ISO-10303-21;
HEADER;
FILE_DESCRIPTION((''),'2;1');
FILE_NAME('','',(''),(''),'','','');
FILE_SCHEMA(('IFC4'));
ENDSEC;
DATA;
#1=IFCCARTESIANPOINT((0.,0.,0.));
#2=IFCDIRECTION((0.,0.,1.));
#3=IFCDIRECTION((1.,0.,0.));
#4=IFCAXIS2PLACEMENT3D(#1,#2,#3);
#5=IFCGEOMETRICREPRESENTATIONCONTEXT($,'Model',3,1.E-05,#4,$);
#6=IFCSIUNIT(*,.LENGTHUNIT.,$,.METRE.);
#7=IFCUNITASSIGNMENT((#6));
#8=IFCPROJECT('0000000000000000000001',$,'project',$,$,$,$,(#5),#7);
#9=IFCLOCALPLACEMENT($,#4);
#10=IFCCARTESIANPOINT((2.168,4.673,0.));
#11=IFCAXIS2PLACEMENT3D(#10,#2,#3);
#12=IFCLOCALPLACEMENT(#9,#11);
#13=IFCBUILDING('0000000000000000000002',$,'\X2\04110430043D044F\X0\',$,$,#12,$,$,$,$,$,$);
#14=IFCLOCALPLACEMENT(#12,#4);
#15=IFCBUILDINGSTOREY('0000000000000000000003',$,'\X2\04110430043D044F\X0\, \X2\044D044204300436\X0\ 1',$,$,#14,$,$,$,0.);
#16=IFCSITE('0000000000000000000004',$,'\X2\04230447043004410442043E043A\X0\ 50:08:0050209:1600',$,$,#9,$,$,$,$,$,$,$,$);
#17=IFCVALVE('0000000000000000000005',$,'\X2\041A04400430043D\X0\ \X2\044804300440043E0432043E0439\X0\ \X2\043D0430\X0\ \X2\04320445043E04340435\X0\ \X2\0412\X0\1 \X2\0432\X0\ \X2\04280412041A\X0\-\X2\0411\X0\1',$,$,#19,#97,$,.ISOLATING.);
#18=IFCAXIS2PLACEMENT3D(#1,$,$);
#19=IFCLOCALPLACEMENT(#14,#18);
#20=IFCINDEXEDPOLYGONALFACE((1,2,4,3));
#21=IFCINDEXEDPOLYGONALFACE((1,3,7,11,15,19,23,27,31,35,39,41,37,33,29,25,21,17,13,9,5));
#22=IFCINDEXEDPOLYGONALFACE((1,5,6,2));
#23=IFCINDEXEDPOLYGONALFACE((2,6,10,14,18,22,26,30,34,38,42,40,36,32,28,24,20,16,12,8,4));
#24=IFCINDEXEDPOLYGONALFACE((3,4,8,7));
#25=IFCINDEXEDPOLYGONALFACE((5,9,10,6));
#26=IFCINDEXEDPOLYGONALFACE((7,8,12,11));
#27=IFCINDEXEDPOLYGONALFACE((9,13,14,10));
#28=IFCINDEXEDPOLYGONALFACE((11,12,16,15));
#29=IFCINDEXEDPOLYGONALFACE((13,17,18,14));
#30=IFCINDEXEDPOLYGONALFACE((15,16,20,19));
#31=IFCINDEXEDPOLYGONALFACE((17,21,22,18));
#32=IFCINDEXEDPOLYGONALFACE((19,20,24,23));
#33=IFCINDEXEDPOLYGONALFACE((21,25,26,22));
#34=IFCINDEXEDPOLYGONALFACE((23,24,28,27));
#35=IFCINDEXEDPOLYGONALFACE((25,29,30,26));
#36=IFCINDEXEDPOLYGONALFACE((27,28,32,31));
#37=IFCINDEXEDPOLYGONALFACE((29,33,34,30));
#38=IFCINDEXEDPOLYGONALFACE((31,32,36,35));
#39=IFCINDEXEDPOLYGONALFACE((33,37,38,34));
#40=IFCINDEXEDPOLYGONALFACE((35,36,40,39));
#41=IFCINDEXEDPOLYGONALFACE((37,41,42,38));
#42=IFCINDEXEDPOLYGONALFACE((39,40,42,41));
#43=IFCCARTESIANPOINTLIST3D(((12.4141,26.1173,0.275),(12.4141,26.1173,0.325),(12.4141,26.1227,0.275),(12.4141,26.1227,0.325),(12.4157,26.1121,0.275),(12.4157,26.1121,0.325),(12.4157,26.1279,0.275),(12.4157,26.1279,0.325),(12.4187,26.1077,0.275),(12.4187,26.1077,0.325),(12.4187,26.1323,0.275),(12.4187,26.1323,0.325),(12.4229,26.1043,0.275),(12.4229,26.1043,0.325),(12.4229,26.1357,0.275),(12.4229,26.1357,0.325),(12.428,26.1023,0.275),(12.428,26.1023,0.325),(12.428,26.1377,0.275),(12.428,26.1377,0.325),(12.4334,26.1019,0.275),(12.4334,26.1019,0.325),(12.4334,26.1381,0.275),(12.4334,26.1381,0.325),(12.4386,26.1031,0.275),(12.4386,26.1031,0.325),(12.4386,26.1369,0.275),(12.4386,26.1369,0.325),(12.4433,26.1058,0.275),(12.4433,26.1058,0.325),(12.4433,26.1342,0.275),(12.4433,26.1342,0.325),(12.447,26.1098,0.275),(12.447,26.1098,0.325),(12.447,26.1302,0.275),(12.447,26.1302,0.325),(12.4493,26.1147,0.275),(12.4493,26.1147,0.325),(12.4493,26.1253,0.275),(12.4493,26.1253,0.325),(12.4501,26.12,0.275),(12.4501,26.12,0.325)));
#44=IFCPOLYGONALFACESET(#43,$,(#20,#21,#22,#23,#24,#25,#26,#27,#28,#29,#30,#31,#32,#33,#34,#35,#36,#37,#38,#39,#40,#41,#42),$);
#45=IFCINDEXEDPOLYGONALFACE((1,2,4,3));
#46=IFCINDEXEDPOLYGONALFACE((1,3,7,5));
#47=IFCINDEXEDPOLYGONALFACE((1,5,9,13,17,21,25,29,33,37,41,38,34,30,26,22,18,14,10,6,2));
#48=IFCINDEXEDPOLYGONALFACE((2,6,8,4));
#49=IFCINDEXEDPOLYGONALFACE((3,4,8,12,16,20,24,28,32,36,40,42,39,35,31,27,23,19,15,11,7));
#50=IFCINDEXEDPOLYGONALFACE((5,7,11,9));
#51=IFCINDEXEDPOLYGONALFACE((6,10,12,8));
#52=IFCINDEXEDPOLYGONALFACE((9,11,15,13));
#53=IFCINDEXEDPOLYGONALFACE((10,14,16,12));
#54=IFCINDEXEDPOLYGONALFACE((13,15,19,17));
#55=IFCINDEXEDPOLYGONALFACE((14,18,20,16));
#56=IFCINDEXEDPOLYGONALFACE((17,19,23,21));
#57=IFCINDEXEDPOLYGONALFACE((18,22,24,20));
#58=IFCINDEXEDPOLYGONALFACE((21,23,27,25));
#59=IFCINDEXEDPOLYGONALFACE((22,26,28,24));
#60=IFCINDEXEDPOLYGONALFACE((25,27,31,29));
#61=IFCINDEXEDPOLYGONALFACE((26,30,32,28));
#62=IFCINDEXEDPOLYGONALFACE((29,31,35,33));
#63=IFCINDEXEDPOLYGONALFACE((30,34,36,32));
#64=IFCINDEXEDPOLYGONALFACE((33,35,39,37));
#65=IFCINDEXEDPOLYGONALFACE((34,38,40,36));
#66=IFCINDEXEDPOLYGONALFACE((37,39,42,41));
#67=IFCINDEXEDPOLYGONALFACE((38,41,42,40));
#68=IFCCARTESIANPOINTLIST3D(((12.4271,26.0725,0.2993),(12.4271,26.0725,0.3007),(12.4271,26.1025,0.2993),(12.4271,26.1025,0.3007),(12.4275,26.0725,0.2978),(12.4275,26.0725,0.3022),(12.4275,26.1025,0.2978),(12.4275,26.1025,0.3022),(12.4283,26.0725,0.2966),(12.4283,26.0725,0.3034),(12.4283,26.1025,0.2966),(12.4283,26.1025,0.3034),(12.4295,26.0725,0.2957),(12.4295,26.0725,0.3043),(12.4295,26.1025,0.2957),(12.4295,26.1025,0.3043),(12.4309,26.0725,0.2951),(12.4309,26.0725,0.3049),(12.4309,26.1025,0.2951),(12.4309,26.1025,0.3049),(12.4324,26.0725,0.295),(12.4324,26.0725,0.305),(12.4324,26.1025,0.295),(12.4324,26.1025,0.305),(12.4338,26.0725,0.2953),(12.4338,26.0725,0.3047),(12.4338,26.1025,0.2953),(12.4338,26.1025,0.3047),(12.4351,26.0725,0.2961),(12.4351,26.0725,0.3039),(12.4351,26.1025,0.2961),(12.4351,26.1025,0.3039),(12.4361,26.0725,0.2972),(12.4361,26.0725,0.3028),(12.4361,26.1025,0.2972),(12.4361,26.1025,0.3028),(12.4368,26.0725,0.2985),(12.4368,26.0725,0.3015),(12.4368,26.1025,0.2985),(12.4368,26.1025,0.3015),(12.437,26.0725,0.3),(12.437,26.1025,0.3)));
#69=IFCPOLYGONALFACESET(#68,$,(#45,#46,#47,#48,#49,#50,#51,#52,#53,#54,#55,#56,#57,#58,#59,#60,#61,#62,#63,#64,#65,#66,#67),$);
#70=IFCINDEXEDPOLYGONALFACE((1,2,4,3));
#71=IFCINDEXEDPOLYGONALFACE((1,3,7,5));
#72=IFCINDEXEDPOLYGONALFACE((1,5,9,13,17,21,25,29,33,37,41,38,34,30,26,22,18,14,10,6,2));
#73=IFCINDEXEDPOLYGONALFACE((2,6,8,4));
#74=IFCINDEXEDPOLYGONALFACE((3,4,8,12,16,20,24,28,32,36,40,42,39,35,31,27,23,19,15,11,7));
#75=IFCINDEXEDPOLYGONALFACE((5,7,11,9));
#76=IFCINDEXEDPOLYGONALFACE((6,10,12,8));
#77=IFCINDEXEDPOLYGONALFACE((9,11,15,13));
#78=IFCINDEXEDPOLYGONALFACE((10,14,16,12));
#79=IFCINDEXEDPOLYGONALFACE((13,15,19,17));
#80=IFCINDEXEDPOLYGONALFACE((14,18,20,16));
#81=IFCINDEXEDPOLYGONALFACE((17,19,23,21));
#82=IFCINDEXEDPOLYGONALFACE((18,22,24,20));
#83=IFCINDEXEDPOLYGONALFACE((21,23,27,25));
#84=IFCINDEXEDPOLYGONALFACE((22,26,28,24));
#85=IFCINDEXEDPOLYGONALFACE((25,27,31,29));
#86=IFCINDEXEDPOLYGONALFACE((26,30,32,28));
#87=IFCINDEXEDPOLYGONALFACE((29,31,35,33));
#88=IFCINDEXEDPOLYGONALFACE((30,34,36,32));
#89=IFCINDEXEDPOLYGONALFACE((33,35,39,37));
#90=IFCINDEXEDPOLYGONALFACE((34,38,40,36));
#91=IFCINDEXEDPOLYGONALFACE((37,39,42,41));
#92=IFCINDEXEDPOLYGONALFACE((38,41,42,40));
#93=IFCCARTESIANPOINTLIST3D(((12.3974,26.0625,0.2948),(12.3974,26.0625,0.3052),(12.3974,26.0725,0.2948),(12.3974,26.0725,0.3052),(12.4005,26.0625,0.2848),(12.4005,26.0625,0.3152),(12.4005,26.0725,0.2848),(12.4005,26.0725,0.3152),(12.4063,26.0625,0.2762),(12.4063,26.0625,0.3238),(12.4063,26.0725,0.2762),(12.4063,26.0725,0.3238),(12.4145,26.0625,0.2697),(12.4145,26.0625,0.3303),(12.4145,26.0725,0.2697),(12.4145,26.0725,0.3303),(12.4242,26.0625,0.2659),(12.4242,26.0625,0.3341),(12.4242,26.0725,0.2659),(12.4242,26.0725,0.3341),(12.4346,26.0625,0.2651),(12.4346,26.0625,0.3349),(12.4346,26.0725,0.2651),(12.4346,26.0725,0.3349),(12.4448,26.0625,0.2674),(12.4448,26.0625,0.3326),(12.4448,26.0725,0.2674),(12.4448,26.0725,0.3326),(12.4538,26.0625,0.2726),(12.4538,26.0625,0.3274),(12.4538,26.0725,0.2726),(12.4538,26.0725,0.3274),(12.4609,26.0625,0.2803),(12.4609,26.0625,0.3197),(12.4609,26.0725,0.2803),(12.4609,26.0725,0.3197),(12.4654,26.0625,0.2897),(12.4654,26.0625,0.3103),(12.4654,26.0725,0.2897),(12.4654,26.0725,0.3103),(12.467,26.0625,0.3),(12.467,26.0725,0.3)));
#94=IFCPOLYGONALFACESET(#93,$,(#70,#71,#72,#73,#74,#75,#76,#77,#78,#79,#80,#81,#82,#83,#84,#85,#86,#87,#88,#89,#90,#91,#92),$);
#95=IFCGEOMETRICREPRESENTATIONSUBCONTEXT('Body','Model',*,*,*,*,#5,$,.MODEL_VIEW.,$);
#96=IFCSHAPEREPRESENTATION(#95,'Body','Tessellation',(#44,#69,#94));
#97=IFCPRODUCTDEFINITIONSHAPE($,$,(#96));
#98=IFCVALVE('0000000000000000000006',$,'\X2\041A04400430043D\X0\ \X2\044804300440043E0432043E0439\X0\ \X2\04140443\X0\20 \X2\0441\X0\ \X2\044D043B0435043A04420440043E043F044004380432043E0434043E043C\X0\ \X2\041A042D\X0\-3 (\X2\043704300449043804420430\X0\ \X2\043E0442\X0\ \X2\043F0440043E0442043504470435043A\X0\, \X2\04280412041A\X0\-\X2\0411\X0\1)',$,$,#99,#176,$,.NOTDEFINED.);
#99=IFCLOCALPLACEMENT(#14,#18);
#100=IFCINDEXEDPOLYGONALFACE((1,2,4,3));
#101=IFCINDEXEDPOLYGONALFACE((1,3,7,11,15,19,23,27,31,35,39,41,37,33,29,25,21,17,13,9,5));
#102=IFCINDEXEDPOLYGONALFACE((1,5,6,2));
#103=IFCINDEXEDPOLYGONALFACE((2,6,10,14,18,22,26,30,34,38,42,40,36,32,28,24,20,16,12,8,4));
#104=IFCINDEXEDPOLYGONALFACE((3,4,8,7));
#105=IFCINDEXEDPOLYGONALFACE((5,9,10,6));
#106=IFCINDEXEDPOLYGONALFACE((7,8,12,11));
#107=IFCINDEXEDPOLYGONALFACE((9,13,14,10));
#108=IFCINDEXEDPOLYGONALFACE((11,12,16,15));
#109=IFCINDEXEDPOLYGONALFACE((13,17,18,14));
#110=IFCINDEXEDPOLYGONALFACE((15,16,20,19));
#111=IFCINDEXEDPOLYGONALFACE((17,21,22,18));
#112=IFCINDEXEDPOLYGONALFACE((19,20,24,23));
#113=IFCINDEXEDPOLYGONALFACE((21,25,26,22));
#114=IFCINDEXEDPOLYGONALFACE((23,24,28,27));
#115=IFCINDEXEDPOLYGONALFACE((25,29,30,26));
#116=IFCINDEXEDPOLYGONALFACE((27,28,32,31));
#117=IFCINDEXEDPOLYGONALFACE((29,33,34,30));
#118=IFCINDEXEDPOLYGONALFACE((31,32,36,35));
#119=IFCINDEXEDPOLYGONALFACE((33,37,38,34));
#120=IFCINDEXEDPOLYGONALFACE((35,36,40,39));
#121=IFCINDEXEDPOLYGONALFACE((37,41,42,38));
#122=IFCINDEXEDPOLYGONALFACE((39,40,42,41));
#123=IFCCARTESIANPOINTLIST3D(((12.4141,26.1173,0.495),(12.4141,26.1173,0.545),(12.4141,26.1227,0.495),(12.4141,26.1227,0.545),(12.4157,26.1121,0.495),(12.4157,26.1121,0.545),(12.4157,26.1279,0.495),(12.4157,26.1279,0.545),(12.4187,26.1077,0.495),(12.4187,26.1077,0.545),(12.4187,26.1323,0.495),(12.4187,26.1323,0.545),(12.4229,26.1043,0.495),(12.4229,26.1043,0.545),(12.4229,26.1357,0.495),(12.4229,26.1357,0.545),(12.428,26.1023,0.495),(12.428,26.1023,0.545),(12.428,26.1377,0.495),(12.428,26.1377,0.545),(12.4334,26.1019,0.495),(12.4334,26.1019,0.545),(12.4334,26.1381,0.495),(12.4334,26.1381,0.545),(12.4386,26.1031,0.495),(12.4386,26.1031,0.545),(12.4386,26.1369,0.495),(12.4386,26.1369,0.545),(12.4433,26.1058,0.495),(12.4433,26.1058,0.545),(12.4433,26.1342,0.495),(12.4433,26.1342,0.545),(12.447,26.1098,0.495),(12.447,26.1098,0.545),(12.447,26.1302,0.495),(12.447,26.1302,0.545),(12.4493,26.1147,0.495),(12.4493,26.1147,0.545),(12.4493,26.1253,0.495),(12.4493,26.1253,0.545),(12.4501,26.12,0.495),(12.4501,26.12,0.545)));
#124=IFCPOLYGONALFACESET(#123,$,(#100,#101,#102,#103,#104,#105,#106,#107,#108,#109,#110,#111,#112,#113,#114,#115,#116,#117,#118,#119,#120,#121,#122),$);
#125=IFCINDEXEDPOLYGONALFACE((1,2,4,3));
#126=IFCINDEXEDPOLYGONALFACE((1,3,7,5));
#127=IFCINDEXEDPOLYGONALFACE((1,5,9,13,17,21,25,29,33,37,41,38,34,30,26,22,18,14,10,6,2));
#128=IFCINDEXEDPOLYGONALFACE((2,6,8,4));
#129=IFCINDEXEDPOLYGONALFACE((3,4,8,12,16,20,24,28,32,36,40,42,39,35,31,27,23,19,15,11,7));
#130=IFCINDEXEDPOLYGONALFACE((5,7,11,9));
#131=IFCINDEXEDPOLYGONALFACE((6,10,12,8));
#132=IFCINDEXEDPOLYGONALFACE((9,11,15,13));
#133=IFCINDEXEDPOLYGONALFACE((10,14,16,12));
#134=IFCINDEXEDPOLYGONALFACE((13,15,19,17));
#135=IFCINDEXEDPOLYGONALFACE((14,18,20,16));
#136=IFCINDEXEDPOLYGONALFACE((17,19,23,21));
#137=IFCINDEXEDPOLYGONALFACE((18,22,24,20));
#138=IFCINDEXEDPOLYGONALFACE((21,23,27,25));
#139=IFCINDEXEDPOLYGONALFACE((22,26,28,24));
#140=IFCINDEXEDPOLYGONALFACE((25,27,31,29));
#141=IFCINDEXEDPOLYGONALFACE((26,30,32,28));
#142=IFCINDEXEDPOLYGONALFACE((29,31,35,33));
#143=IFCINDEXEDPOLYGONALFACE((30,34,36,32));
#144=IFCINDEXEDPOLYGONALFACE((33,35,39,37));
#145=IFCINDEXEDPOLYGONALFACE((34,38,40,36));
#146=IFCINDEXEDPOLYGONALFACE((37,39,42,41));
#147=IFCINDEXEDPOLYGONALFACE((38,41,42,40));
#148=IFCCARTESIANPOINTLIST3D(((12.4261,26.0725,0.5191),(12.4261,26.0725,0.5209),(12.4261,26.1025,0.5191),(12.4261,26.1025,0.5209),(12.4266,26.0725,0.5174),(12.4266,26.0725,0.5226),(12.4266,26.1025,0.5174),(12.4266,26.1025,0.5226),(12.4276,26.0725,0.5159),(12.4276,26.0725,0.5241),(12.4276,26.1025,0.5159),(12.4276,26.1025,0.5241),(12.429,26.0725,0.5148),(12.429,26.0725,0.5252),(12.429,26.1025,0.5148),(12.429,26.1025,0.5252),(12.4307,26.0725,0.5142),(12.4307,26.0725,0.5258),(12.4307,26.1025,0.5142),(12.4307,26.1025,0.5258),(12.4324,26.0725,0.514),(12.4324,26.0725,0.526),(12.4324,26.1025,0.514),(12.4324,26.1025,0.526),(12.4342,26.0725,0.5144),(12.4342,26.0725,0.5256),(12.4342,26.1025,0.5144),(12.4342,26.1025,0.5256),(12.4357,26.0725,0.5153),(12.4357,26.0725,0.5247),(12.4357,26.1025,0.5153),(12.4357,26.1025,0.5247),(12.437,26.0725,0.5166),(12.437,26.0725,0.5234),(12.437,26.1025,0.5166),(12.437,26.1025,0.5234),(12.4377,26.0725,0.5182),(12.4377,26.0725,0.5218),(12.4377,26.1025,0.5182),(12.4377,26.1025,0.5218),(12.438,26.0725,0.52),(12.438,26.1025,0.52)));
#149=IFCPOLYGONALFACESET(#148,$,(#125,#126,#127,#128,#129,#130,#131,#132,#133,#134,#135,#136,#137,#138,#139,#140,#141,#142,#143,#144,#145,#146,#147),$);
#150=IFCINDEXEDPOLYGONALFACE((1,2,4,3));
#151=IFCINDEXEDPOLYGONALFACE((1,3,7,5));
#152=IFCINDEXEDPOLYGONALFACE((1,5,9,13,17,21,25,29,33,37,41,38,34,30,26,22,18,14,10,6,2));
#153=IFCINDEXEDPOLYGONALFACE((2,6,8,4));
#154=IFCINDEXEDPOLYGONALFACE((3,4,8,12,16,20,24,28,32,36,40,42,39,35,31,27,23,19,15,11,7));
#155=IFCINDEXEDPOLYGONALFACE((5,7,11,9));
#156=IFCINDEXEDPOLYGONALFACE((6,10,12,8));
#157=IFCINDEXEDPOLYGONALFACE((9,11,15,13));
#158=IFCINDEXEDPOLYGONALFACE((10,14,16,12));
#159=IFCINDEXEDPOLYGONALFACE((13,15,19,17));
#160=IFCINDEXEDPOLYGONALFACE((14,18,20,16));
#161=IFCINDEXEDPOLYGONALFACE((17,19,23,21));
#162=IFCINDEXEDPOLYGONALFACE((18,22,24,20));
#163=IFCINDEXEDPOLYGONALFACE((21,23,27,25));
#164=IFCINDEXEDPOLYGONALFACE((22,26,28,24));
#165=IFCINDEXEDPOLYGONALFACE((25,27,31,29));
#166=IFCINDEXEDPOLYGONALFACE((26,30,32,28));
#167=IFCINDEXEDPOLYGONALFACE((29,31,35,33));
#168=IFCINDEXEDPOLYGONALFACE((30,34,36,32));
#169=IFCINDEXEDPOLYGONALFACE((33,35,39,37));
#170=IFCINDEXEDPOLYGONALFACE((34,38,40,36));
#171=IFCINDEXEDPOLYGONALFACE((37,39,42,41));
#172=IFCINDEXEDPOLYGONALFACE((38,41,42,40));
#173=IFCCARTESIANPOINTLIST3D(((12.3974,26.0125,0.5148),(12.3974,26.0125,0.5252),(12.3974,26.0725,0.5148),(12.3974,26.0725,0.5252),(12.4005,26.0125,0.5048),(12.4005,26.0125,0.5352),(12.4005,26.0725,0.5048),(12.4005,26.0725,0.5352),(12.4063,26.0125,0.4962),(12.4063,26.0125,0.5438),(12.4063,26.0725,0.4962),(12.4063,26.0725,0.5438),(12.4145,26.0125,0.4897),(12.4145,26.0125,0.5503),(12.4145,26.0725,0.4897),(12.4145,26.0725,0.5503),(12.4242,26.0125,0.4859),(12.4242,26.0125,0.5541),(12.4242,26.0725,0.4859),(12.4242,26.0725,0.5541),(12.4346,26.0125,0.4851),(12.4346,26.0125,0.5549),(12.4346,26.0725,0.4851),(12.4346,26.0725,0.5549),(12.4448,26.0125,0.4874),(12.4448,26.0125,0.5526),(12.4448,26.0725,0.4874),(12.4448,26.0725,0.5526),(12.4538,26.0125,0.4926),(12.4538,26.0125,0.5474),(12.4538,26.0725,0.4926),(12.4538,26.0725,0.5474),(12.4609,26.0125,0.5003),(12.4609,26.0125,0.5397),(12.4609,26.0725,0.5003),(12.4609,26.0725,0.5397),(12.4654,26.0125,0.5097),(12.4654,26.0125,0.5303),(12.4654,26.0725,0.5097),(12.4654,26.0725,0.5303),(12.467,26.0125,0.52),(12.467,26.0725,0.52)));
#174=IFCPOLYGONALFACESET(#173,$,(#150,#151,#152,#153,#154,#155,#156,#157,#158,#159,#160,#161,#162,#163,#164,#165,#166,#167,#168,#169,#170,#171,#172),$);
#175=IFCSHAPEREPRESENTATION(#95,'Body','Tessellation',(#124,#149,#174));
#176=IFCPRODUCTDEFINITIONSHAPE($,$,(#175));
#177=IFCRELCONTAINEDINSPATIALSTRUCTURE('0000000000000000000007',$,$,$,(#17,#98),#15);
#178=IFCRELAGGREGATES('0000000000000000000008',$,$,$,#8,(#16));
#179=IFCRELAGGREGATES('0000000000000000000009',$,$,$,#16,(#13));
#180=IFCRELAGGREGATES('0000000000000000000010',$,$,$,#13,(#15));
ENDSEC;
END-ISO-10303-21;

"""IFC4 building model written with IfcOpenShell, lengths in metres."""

from ifc_helpers import new_model, si_unit, frame, origin_with_axes, origin_2d, place, context, subcontext, project, spatial, circle, extrude, element, save


model = new_model("IFC4")

# Units and contexts
model_context = context("Model", 3, precision=1e-05, world=origin_with_axes())
body_context = subcontext(model_context, "Body", "Model", "MODEL_VIEW")
ifc_project = project(units=[si_unit("LENGTHUNIT", "METRE")], contexts=[model_context])

# Site, building, storey
site_placement = place(None, origin_with_axes())
site = spatial("IfcSite", under=ifc_project, at=site_placement, Name="Участок 50:08:0050209:1600")
building_placement = place(site_placement, frame((2.168, 4.673, 0.0), z_axis=(0.0, 0.0, 1.0), x_axis=(1.0, 0.0, 0.0)))
building = spatial("IfcBuilding", under=site, at=building_placement, Name="Баня")
storey_placement = place(building_placement, origin_with_axes())
storey = spatial("IfcBuildingStorey", under=building, at=storey_placement, Name="Баня, этаж 1", Elevation=0.0)

# Valves
valve_1_placement = place(storey_placement, origin_with_axes())
element("IfcValve", 1, at=valve_1_placement, inside=storey, Name="Кран шаровой на входе В1 в ШВК-Б1", PredefinedType="ISOLATING", context=body_context, shape_type="SweptSolid", body=[
    extrude(circle(Radius=0.0181, at=origin_2d()), frame((12.432, 26.12, 0.275), z_axis=(0.0, 0.0, 1.0), x_axis=(1.0, 0.0, 0.0)), (0.0, 0.0, 1.0), 0.05),
    extrude(circle(Radius=0.005, at=origin_2d()), frame((12.432, 26.1025, 0.3), z_axis=(0.0, -1.0, 0.0), x_axis=(1.0, 0.0, 0.0)), (0.0, 0.0, 1.0), 0.03),
    extrude(circle(Radius=0.035, at=origin_2d()), frame((12.432, 26.0725, 0.3), z_axis=(0.0, -1.0, 0.0), x_axis=(1.0, 0.0, 0.0)), (0.0, 0.0, 1.0), 0.01),
])
valve_2_placement = place(storey_placement, origin_with_axes())
element("IfcValve", 2, at=valve_2_placement, inside=storey, Name="Кран шаровой Ду20 с электроприводом КЭ-3 (защита от протечек, ШВК-Б1)", PredefinedType="NOTDEFINED", context=body_context, shape_type="SweptSolid", body=[
    extrude(circle(Radius=0.0181, at=origin_2d()), frame((12.432, 26.12, 0.495), z_axis=(0.0, 0.0, 1.0), x_axis=(1.0, 0.0, 0.0)), (0.0, 0.0, 1.0), 0.05),
    extrude(circle(Radius=0.006, at=origin_2d()), frame((12.432, 26.1025, 0.52), z_axis=(0.0, -1.0, 0.0), x_axis=(1.0, 0.0, 0.0)), (0.0, 0.0, 1.0), 0.03),
    extrude(circle(Radius=0.035, at=origin_2d()), frame((12.432, 26.0725, 0.52), z_axis=(0.0, -1.0, 0.0), x_axis=(1.0, 0.0, 0.0)), (0.0, 0.0, 1.0), 0.06),
])

save(model, "model.ifc")
